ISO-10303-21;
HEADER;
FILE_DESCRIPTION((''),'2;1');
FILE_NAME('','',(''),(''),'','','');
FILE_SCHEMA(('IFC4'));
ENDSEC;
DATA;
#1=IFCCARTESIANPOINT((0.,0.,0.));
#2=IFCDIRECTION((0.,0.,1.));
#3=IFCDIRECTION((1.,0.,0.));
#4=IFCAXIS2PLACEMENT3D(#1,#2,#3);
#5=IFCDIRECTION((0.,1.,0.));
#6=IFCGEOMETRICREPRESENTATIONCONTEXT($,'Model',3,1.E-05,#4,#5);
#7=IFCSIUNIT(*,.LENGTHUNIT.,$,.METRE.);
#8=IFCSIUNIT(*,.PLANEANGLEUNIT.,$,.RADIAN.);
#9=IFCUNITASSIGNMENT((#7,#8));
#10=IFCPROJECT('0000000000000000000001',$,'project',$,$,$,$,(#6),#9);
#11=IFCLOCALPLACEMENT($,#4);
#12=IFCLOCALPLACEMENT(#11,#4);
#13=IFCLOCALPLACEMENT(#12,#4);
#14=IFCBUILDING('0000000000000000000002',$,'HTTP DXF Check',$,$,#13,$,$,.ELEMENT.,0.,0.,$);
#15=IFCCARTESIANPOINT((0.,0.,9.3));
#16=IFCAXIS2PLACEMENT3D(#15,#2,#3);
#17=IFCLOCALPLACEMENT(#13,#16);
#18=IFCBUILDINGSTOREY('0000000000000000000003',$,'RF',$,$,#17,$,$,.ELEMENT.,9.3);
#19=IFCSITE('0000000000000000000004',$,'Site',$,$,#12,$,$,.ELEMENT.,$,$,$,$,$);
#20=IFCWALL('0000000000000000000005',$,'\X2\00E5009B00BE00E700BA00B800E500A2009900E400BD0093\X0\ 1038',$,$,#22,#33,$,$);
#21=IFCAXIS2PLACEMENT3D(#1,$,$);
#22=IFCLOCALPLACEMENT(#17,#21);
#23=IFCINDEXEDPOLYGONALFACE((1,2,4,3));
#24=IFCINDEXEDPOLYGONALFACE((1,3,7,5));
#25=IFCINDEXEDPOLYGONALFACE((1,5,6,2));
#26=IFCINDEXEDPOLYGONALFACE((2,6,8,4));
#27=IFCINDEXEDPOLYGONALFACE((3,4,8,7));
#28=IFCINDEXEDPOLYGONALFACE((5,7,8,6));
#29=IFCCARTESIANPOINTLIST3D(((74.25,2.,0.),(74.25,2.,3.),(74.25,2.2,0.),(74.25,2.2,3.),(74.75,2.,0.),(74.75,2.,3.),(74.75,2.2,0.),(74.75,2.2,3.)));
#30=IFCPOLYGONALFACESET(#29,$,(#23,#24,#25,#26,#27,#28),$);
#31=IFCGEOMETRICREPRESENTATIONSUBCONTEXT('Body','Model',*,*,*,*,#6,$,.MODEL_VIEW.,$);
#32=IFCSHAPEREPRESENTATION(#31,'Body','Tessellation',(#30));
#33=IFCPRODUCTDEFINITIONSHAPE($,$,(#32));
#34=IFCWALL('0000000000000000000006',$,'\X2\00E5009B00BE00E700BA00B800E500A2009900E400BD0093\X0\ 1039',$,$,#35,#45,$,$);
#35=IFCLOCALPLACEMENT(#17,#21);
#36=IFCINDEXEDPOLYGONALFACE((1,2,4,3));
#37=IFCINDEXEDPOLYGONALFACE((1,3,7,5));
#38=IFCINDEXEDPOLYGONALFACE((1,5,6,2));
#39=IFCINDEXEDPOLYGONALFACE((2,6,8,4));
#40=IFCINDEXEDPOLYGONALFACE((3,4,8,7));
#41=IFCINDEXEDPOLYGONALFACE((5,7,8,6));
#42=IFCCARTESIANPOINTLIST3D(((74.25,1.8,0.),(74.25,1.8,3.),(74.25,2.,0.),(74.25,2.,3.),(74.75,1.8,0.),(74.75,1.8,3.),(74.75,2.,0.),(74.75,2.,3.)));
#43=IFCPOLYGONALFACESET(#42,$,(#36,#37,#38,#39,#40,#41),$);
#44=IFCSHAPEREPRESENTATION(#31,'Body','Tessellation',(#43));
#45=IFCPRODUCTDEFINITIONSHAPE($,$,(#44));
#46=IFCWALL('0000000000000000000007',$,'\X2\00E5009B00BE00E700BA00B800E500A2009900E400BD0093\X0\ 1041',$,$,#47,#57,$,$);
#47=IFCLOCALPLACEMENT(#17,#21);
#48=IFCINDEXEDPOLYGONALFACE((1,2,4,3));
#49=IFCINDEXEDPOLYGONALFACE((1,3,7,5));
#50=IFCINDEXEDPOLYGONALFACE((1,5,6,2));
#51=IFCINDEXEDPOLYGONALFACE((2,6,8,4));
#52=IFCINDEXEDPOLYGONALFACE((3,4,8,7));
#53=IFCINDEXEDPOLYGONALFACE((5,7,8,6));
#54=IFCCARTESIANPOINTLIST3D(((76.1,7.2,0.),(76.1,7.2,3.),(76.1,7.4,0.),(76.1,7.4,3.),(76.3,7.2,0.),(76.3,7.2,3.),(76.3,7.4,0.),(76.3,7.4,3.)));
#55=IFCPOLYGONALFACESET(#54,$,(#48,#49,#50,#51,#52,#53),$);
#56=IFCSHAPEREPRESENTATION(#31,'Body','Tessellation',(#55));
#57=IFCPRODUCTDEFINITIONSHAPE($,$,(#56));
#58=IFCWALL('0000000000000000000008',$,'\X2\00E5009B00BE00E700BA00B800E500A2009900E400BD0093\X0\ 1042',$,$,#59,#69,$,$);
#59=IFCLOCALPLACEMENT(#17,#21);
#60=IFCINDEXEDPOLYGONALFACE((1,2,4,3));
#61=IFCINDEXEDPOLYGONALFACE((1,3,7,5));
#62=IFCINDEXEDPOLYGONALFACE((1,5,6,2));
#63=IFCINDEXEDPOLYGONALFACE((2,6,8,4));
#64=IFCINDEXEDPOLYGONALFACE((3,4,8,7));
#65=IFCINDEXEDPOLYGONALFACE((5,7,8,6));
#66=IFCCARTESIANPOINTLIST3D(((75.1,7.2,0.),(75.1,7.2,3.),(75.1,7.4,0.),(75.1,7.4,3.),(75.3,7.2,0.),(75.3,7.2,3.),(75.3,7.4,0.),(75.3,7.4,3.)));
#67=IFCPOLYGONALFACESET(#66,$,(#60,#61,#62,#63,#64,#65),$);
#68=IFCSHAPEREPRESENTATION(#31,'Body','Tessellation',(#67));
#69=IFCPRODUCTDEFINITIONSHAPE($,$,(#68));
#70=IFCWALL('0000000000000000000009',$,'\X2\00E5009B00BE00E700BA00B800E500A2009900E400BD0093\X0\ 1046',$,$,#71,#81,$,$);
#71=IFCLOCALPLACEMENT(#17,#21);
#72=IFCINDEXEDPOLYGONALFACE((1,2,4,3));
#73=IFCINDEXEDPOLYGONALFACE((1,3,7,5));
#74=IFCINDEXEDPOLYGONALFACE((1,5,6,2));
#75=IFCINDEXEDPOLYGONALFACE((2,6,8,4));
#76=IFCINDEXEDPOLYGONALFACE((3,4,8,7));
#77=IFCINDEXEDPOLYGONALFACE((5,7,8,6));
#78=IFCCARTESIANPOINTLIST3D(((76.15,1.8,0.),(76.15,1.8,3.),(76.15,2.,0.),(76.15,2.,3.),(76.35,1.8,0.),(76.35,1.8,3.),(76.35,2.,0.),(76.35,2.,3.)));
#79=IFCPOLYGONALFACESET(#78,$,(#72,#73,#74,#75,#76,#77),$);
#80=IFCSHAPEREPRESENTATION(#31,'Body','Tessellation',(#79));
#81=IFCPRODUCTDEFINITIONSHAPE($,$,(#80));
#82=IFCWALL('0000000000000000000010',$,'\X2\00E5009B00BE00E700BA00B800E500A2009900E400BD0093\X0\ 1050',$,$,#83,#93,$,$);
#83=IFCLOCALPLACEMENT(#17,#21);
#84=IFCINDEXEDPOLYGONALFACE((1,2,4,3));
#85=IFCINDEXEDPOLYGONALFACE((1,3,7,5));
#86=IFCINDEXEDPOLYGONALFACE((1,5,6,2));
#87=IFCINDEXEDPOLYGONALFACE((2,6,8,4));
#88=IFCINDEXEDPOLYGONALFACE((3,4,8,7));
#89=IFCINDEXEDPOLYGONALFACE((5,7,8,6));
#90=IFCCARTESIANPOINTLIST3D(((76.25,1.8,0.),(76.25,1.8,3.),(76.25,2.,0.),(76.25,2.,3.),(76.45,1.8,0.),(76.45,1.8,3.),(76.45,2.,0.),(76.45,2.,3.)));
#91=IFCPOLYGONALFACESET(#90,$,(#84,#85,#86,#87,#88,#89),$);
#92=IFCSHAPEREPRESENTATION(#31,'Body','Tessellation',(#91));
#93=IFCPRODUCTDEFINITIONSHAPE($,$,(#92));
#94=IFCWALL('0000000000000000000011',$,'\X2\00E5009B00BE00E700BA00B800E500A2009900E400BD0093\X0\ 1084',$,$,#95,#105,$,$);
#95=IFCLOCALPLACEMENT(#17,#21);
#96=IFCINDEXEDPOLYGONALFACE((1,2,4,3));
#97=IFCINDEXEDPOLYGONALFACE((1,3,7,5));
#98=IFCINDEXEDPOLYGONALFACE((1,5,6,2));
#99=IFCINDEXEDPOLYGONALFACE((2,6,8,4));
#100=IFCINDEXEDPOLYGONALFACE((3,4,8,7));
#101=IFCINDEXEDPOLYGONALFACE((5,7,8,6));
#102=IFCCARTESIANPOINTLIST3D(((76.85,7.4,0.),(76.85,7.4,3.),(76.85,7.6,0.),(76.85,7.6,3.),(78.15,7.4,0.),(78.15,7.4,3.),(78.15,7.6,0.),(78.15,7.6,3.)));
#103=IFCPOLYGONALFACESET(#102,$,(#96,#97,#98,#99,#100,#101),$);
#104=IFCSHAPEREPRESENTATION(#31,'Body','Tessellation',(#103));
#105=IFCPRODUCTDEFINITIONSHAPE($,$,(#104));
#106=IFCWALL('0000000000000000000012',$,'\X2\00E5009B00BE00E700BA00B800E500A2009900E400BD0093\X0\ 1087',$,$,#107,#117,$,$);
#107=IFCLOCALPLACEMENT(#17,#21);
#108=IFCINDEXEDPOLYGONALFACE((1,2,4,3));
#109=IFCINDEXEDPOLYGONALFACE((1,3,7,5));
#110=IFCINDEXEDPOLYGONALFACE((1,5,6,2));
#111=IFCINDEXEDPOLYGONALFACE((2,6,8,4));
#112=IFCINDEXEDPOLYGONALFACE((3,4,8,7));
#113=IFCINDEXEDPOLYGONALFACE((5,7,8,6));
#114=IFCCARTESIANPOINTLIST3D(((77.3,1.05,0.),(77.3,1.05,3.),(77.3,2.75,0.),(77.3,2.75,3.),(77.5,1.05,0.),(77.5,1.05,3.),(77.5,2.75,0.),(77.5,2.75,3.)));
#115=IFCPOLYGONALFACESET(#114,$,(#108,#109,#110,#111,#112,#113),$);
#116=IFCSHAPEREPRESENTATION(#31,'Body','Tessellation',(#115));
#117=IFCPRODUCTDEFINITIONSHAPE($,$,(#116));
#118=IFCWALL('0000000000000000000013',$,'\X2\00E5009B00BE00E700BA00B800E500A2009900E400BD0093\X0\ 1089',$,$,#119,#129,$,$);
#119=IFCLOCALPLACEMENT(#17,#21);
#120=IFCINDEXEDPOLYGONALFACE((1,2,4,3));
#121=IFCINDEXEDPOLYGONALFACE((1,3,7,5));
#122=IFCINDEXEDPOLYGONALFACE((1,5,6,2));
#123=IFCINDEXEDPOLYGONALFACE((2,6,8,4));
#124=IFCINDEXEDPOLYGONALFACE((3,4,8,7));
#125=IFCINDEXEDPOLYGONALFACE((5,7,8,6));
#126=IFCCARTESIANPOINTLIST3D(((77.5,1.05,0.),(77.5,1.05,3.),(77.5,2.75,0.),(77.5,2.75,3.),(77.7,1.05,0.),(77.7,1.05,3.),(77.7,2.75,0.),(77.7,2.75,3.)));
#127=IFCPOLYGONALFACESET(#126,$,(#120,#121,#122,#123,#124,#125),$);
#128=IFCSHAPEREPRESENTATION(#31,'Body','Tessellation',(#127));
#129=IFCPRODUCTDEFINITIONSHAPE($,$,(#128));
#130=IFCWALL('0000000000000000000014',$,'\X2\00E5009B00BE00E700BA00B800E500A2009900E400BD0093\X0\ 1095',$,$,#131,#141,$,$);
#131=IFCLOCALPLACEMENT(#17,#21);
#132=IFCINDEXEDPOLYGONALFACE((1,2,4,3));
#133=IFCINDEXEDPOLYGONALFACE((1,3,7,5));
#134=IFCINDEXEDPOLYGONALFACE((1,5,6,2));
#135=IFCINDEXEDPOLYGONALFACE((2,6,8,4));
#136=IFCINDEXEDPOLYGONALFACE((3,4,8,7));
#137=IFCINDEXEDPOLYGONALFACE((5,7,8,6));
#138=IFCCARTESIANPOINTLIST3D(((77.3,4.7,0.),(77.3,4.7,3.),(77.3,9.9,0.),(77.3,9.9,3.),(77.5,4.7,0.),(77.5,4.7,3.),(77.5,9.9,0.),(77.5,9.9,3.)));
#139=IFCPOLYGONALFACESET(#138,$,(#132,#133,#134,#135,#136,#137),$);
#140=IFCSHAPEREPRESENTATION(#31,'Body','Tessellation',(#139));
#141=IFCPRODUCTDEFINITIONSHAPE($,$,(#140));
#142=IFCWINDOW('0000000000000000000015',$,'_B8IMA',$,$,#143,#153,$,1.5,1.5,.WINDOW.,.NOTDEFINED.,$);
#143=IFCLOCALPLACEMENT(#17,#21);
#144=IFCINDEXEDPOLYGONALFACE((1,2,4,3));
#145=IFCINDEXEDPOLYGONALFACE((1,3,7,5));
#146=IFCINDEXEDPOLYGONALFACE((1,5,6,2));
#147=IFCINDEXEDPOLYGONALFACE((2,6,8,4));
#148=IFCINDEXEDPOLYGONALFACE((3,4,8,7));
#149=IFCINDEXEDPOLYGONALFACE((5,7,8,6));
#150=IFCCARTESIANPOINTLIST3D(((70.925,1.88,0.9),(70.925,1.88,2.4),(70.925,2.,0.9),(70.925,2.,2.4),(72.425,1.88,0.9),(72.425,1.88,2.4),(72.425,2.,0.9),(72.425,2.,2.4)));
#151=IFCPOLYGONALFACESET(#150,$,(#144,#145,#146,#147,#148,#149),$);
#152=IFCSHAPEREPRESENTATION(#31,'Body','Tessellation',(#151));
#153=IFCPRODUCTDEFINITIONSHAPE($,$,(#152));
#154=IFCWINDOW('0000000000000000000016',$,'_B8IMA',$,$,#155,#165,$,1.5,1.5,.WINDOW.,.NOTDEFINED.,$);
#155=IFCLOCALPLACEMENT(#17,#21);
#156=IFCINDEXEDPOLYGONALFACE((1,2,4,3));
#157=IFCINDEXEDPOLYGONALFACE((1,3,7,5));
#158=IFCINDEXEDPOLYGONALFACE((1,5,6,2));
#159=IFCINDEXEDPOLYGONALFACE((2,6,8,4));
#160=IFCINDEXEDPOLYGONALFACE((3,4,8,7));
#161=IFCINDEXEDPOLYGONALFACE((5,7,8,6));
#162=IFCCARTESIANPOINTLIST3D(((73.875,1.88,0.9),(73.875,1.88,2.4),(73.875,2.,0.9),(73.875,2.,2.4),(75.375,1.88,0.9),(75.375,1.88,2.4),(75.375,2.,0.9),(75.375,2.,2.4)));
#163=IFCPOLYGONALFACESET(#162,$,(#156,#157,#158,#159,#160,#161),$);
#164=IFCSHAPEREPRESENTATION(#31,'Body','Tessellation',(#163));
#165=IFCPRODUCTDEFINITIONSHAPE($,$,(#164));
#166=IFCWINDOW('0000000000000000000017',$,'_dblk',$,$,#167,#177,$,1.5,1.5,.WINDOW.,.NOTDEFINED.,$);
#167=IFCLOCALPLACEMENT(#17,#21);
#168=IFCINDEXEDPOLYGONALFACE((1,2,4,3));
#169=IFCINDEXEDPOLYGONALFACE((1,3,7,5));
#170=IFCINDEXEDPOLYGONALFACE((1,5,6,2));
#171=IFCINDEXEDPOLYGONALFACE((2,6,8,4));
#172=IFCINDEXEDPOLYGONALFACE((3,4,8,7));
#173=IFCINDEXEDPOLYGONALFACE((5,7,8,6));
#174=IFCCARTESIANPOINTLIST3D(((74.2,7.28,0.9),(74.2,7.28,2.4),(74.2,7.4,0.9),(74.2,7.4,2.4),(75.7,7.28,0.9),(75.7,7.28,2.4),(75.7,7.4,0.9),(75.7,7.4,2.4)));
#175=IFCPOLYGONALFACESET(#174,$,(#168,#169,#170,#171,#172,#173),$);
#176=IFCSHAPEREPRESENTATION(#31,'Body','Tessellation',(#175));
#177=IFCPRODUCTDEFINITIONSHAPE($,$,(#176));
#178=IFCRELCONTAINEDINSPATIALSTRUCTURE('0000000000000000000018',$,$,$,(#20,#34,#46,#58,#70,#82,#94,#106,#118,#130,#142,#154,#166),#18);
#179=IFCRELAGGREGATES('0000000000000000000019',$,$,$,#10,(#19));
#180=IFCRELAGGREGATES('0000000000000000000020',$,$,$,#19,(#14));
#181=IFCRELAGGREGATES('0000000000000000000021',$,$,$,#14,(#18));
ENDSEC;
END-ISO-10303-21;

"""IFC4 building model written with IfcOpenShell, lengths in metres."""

from ifc_helpers import new_model, si_unit, direction, frame, frame_2d, origin_with_axes, place, context, subcontext, project, spatial, rectangle, extrude, element, save


model = new_model("IFC4")

# Units and contexts
model_context = context("Model", 3, precision=1e-05, world=origin_with_axes(), true_north=direction((0.0, 1.0, 0.0)))
body_context = subcontext(model_context, "Body", "Model", "MODEL_VIEW")
ifc_project = project(units=[si_unit("LENGTHUNIT", "METRE"), si_unit("PLANEANGLEUNIT", "RADIAN")], contexts=[model_context])

# Site, building, storey
placement = place(None, origin_with_axes())
site_placement = place(placement, origin_with_axes())
site = spatial("IfcSite", under=ifc_project, at=site_placement, Name="Site", CompositionType="ELEMENT")
building_placement = place(site_placement, origin_with_axes())
building = spatial("IfcBuilding", under=site, at=building_placement, Name="HTTP DXF Check", CompositionType="ELEMENT", ElevationOfRefHeight=0.0, ElevationOfTerrain=0.0)
storey_placement = place(building_placement, frame((0.0, 0.0, 9.3), z_axis=(0.0, 0.0, 1.0), x_axis=(1.0, 0.0, 0.0)))
storey = spatial("IfcBuildingStorey", under=building, at=storey_placement, Name="RF", CompositionType="ELEMENT", Elevation=9.3)

# Walls
for number, where, z_axis, x_axis, name in (
    (1, (74.5, 2.1, 0.0), (0.0, 0.0, 1.0), (-1.0, 0.0, 0.0), "å\u009b¾çº¸å¢\u0099ä½\u0093 1038"),
    (2, (74.5, 1.9, 0.0), (0.0, 0.0, 1.0), (-1.0, 0.0, 0.0), "å\u009b¾çº¸å¢\u0099ä½\u0093 1039"),
):
    element("IfcWall", number, at=place(storey_placement, frame(where, z_axis=z_axis, x_axis=x_axis)), inside=storey, Name=name, context=body_context, shape_type="SweptSolid", body=[
        extrude(rectangle(XDim=0.5, YDim=0.2, at=frame_2d((0.0, 0.0), x_axis=(1.0, 0.0, 0.0))), frame((0.0, 0.0, 0.0), z_axis=(0.0, 0.0, 1.0)), (0.0, 0.0, 1.0), 3.0),
    ])
for number, where, z_axis, x_axis, name in (
    (3, (76.2, 7.3, 0.0), (0.0, 0.0, 1.0), (0.0, 1.0, 0.0), "å\u009b¾çº¸å¢\u0099ä½\u0093 1041"),
    (4, (75.2, 7.3, 0.0), (0.0, 0.0, 1.0), (0.0, 1.0, 0.0), "å\u009b¾çº¸å¢\u0099ä½\u0093 1042"),
    (5, (76.25, 1.9, 0.0), (0.0, 0.0, 1.0), (0.0, 1.0, 0.0), "å\u009b¾çº¸å¢\u0099ä½\u0093 1046"),
    (6, (76.35, 1.9, 0.0), (0.0, 0.0, 1.0), (0.0, -1.0, 0.0), "å\u009b¾çº¸å¢\u0099ä½\u0093 1050"),
):
    element("IfcWall", number, at=place(storey_placement, frame(where, z_axis=z_axis, x_axis=x_axis)), inside=storey, Name=name, context=body_context, shape_type="SweptSolid", body=[
        extrude(rectangle(XDim=0.2, YDim=0.2, at=frame_2d((0.0, 0.0), x_axis=(1.0, 0.0, 0.0))), frame((0.0, 0.0, 0.0), z_axis=(0.0, 0.0, 1.0)), (0.0, 0.0, 1.0), 3.0),
    ])
wall_1_placement = place(storey_placement, frame((77.5, 7.5, 0.0), z_axis=(0.0, 0.0, 1.0), x_axis=(1.0, 0.0, 0.0)))
element("IfcWall", 7, at=wall_1_placement, inside=storey, Name="å\u009b¾çº¸å¢\u0099ä½\u0093 1084", context=body_context, shape_type="SweptSolid", body=[
    extrude(rectangle(XDim=1.3, YDim=0.2, at=frame_2d((0.0, 0.0), x_axis=(1.0, 0.0, 0.0))), frame((0.0, 0.0, 0.0), z_axis=(0.0, 0.0, 1.0)), (0.0, 0.0, 1.0), 3.0),
])
for number, where, z_axis, x_axis, name in (
    (8, (77.4, 1.9, 0.0), (0.0, 0.0, 1.0), (0.0, -1.0, 0.0), "å\u009b¾çº¸å¢\u0099ä½\u0093 1087"),
    (9, (77.6, 1.9, 0.0), (0.0, 0.0, 1.0), (0.0, -1.0, 0.0), "å\u009b¾çº¸å¢\u0099ä½\u0093 1089"),
):
    element("IfcWall", number, at=place(storey_placement, frame(where, z_axis=z_axis, x_axis=x_axis)), inside=storey, Name=name, context=body_context, shape_type="SweptSolid", body=[
        extrude(rectangle(XDim=1.7, YDim=0.2, at=frame_2d((0.0, 0.0), x_axis=(1.0, 0.0, 0.0))), frame((0.0, 0.0, 0.0), z_axis=(0.0, 0.0, 1.0)), (0.0, 0.0, 1.0), 3.0),
    ])
wall_2_placement = place(storey_placement, frame((77.4, 7.3, 0.0), z_axis=(0.0, 0.0, 1.0), x_axis=(0.0, -1.0, 0.0)))
element("IfcWall", 10, at=wall_2_placement, inside=storey, Name="å\u009b¾çº¸å¢\u0099ä½\u0093 1095", context=body_context, shape_type="SweptSolid", body=[
    extrude(rectangle(XDim=5.2, YDim=0.2, at=frame_2d((0.0, 0.0), x_axis=(1.0, 0.0, 0.0))), frame((0.0, 0.0, 0.0), z_axis=(0.0, 0.0, 1.0)), (0.0, 0.0, 1.0), 3.0),
])

# Windows
for number, where, z_axis, x_axis, name in (
    (11, (71.675, 1.94, 0.9), (0.0, 0.0, 1.0), (1.0, 0.0, 0.0), "_B8IMA"),
    (12, (74.625, 1.94, 0.9), (0.0, 0.0, 1.0), (1.0, 0.0, 0.0), "_B8IMA"),
    (13, (74.95, 7.34, 0.9), (0.0, 0.0, 1.0), (1.0, 0.0, 0.0), "_dblk"),
):
    element("IfcWindow", number, at=place(storey_placement, frame(where, z_axis=z_axis, x_axis=x_axis)), inside=storey, Name=name, OverallHeight=1.5, OverallWidth=1.5, PartitioningType="NOTDEFINED", PredefinedType="WINDOW", context=body_context, shape_type="SweptSolid", body=[
        extrude(rectangle(XDim=1.5, YDim=0.12, at=frame_2d((0.0, 0.0), x_axis=(1.0, 0.0, 0.0))), frame((0.0, 0.0, 0.0), z_axis=(0.0, 0.0, 1.0)), (0.0, 0.0, 1.0), 1.5),
    ])

save(model, "model.ifc")
